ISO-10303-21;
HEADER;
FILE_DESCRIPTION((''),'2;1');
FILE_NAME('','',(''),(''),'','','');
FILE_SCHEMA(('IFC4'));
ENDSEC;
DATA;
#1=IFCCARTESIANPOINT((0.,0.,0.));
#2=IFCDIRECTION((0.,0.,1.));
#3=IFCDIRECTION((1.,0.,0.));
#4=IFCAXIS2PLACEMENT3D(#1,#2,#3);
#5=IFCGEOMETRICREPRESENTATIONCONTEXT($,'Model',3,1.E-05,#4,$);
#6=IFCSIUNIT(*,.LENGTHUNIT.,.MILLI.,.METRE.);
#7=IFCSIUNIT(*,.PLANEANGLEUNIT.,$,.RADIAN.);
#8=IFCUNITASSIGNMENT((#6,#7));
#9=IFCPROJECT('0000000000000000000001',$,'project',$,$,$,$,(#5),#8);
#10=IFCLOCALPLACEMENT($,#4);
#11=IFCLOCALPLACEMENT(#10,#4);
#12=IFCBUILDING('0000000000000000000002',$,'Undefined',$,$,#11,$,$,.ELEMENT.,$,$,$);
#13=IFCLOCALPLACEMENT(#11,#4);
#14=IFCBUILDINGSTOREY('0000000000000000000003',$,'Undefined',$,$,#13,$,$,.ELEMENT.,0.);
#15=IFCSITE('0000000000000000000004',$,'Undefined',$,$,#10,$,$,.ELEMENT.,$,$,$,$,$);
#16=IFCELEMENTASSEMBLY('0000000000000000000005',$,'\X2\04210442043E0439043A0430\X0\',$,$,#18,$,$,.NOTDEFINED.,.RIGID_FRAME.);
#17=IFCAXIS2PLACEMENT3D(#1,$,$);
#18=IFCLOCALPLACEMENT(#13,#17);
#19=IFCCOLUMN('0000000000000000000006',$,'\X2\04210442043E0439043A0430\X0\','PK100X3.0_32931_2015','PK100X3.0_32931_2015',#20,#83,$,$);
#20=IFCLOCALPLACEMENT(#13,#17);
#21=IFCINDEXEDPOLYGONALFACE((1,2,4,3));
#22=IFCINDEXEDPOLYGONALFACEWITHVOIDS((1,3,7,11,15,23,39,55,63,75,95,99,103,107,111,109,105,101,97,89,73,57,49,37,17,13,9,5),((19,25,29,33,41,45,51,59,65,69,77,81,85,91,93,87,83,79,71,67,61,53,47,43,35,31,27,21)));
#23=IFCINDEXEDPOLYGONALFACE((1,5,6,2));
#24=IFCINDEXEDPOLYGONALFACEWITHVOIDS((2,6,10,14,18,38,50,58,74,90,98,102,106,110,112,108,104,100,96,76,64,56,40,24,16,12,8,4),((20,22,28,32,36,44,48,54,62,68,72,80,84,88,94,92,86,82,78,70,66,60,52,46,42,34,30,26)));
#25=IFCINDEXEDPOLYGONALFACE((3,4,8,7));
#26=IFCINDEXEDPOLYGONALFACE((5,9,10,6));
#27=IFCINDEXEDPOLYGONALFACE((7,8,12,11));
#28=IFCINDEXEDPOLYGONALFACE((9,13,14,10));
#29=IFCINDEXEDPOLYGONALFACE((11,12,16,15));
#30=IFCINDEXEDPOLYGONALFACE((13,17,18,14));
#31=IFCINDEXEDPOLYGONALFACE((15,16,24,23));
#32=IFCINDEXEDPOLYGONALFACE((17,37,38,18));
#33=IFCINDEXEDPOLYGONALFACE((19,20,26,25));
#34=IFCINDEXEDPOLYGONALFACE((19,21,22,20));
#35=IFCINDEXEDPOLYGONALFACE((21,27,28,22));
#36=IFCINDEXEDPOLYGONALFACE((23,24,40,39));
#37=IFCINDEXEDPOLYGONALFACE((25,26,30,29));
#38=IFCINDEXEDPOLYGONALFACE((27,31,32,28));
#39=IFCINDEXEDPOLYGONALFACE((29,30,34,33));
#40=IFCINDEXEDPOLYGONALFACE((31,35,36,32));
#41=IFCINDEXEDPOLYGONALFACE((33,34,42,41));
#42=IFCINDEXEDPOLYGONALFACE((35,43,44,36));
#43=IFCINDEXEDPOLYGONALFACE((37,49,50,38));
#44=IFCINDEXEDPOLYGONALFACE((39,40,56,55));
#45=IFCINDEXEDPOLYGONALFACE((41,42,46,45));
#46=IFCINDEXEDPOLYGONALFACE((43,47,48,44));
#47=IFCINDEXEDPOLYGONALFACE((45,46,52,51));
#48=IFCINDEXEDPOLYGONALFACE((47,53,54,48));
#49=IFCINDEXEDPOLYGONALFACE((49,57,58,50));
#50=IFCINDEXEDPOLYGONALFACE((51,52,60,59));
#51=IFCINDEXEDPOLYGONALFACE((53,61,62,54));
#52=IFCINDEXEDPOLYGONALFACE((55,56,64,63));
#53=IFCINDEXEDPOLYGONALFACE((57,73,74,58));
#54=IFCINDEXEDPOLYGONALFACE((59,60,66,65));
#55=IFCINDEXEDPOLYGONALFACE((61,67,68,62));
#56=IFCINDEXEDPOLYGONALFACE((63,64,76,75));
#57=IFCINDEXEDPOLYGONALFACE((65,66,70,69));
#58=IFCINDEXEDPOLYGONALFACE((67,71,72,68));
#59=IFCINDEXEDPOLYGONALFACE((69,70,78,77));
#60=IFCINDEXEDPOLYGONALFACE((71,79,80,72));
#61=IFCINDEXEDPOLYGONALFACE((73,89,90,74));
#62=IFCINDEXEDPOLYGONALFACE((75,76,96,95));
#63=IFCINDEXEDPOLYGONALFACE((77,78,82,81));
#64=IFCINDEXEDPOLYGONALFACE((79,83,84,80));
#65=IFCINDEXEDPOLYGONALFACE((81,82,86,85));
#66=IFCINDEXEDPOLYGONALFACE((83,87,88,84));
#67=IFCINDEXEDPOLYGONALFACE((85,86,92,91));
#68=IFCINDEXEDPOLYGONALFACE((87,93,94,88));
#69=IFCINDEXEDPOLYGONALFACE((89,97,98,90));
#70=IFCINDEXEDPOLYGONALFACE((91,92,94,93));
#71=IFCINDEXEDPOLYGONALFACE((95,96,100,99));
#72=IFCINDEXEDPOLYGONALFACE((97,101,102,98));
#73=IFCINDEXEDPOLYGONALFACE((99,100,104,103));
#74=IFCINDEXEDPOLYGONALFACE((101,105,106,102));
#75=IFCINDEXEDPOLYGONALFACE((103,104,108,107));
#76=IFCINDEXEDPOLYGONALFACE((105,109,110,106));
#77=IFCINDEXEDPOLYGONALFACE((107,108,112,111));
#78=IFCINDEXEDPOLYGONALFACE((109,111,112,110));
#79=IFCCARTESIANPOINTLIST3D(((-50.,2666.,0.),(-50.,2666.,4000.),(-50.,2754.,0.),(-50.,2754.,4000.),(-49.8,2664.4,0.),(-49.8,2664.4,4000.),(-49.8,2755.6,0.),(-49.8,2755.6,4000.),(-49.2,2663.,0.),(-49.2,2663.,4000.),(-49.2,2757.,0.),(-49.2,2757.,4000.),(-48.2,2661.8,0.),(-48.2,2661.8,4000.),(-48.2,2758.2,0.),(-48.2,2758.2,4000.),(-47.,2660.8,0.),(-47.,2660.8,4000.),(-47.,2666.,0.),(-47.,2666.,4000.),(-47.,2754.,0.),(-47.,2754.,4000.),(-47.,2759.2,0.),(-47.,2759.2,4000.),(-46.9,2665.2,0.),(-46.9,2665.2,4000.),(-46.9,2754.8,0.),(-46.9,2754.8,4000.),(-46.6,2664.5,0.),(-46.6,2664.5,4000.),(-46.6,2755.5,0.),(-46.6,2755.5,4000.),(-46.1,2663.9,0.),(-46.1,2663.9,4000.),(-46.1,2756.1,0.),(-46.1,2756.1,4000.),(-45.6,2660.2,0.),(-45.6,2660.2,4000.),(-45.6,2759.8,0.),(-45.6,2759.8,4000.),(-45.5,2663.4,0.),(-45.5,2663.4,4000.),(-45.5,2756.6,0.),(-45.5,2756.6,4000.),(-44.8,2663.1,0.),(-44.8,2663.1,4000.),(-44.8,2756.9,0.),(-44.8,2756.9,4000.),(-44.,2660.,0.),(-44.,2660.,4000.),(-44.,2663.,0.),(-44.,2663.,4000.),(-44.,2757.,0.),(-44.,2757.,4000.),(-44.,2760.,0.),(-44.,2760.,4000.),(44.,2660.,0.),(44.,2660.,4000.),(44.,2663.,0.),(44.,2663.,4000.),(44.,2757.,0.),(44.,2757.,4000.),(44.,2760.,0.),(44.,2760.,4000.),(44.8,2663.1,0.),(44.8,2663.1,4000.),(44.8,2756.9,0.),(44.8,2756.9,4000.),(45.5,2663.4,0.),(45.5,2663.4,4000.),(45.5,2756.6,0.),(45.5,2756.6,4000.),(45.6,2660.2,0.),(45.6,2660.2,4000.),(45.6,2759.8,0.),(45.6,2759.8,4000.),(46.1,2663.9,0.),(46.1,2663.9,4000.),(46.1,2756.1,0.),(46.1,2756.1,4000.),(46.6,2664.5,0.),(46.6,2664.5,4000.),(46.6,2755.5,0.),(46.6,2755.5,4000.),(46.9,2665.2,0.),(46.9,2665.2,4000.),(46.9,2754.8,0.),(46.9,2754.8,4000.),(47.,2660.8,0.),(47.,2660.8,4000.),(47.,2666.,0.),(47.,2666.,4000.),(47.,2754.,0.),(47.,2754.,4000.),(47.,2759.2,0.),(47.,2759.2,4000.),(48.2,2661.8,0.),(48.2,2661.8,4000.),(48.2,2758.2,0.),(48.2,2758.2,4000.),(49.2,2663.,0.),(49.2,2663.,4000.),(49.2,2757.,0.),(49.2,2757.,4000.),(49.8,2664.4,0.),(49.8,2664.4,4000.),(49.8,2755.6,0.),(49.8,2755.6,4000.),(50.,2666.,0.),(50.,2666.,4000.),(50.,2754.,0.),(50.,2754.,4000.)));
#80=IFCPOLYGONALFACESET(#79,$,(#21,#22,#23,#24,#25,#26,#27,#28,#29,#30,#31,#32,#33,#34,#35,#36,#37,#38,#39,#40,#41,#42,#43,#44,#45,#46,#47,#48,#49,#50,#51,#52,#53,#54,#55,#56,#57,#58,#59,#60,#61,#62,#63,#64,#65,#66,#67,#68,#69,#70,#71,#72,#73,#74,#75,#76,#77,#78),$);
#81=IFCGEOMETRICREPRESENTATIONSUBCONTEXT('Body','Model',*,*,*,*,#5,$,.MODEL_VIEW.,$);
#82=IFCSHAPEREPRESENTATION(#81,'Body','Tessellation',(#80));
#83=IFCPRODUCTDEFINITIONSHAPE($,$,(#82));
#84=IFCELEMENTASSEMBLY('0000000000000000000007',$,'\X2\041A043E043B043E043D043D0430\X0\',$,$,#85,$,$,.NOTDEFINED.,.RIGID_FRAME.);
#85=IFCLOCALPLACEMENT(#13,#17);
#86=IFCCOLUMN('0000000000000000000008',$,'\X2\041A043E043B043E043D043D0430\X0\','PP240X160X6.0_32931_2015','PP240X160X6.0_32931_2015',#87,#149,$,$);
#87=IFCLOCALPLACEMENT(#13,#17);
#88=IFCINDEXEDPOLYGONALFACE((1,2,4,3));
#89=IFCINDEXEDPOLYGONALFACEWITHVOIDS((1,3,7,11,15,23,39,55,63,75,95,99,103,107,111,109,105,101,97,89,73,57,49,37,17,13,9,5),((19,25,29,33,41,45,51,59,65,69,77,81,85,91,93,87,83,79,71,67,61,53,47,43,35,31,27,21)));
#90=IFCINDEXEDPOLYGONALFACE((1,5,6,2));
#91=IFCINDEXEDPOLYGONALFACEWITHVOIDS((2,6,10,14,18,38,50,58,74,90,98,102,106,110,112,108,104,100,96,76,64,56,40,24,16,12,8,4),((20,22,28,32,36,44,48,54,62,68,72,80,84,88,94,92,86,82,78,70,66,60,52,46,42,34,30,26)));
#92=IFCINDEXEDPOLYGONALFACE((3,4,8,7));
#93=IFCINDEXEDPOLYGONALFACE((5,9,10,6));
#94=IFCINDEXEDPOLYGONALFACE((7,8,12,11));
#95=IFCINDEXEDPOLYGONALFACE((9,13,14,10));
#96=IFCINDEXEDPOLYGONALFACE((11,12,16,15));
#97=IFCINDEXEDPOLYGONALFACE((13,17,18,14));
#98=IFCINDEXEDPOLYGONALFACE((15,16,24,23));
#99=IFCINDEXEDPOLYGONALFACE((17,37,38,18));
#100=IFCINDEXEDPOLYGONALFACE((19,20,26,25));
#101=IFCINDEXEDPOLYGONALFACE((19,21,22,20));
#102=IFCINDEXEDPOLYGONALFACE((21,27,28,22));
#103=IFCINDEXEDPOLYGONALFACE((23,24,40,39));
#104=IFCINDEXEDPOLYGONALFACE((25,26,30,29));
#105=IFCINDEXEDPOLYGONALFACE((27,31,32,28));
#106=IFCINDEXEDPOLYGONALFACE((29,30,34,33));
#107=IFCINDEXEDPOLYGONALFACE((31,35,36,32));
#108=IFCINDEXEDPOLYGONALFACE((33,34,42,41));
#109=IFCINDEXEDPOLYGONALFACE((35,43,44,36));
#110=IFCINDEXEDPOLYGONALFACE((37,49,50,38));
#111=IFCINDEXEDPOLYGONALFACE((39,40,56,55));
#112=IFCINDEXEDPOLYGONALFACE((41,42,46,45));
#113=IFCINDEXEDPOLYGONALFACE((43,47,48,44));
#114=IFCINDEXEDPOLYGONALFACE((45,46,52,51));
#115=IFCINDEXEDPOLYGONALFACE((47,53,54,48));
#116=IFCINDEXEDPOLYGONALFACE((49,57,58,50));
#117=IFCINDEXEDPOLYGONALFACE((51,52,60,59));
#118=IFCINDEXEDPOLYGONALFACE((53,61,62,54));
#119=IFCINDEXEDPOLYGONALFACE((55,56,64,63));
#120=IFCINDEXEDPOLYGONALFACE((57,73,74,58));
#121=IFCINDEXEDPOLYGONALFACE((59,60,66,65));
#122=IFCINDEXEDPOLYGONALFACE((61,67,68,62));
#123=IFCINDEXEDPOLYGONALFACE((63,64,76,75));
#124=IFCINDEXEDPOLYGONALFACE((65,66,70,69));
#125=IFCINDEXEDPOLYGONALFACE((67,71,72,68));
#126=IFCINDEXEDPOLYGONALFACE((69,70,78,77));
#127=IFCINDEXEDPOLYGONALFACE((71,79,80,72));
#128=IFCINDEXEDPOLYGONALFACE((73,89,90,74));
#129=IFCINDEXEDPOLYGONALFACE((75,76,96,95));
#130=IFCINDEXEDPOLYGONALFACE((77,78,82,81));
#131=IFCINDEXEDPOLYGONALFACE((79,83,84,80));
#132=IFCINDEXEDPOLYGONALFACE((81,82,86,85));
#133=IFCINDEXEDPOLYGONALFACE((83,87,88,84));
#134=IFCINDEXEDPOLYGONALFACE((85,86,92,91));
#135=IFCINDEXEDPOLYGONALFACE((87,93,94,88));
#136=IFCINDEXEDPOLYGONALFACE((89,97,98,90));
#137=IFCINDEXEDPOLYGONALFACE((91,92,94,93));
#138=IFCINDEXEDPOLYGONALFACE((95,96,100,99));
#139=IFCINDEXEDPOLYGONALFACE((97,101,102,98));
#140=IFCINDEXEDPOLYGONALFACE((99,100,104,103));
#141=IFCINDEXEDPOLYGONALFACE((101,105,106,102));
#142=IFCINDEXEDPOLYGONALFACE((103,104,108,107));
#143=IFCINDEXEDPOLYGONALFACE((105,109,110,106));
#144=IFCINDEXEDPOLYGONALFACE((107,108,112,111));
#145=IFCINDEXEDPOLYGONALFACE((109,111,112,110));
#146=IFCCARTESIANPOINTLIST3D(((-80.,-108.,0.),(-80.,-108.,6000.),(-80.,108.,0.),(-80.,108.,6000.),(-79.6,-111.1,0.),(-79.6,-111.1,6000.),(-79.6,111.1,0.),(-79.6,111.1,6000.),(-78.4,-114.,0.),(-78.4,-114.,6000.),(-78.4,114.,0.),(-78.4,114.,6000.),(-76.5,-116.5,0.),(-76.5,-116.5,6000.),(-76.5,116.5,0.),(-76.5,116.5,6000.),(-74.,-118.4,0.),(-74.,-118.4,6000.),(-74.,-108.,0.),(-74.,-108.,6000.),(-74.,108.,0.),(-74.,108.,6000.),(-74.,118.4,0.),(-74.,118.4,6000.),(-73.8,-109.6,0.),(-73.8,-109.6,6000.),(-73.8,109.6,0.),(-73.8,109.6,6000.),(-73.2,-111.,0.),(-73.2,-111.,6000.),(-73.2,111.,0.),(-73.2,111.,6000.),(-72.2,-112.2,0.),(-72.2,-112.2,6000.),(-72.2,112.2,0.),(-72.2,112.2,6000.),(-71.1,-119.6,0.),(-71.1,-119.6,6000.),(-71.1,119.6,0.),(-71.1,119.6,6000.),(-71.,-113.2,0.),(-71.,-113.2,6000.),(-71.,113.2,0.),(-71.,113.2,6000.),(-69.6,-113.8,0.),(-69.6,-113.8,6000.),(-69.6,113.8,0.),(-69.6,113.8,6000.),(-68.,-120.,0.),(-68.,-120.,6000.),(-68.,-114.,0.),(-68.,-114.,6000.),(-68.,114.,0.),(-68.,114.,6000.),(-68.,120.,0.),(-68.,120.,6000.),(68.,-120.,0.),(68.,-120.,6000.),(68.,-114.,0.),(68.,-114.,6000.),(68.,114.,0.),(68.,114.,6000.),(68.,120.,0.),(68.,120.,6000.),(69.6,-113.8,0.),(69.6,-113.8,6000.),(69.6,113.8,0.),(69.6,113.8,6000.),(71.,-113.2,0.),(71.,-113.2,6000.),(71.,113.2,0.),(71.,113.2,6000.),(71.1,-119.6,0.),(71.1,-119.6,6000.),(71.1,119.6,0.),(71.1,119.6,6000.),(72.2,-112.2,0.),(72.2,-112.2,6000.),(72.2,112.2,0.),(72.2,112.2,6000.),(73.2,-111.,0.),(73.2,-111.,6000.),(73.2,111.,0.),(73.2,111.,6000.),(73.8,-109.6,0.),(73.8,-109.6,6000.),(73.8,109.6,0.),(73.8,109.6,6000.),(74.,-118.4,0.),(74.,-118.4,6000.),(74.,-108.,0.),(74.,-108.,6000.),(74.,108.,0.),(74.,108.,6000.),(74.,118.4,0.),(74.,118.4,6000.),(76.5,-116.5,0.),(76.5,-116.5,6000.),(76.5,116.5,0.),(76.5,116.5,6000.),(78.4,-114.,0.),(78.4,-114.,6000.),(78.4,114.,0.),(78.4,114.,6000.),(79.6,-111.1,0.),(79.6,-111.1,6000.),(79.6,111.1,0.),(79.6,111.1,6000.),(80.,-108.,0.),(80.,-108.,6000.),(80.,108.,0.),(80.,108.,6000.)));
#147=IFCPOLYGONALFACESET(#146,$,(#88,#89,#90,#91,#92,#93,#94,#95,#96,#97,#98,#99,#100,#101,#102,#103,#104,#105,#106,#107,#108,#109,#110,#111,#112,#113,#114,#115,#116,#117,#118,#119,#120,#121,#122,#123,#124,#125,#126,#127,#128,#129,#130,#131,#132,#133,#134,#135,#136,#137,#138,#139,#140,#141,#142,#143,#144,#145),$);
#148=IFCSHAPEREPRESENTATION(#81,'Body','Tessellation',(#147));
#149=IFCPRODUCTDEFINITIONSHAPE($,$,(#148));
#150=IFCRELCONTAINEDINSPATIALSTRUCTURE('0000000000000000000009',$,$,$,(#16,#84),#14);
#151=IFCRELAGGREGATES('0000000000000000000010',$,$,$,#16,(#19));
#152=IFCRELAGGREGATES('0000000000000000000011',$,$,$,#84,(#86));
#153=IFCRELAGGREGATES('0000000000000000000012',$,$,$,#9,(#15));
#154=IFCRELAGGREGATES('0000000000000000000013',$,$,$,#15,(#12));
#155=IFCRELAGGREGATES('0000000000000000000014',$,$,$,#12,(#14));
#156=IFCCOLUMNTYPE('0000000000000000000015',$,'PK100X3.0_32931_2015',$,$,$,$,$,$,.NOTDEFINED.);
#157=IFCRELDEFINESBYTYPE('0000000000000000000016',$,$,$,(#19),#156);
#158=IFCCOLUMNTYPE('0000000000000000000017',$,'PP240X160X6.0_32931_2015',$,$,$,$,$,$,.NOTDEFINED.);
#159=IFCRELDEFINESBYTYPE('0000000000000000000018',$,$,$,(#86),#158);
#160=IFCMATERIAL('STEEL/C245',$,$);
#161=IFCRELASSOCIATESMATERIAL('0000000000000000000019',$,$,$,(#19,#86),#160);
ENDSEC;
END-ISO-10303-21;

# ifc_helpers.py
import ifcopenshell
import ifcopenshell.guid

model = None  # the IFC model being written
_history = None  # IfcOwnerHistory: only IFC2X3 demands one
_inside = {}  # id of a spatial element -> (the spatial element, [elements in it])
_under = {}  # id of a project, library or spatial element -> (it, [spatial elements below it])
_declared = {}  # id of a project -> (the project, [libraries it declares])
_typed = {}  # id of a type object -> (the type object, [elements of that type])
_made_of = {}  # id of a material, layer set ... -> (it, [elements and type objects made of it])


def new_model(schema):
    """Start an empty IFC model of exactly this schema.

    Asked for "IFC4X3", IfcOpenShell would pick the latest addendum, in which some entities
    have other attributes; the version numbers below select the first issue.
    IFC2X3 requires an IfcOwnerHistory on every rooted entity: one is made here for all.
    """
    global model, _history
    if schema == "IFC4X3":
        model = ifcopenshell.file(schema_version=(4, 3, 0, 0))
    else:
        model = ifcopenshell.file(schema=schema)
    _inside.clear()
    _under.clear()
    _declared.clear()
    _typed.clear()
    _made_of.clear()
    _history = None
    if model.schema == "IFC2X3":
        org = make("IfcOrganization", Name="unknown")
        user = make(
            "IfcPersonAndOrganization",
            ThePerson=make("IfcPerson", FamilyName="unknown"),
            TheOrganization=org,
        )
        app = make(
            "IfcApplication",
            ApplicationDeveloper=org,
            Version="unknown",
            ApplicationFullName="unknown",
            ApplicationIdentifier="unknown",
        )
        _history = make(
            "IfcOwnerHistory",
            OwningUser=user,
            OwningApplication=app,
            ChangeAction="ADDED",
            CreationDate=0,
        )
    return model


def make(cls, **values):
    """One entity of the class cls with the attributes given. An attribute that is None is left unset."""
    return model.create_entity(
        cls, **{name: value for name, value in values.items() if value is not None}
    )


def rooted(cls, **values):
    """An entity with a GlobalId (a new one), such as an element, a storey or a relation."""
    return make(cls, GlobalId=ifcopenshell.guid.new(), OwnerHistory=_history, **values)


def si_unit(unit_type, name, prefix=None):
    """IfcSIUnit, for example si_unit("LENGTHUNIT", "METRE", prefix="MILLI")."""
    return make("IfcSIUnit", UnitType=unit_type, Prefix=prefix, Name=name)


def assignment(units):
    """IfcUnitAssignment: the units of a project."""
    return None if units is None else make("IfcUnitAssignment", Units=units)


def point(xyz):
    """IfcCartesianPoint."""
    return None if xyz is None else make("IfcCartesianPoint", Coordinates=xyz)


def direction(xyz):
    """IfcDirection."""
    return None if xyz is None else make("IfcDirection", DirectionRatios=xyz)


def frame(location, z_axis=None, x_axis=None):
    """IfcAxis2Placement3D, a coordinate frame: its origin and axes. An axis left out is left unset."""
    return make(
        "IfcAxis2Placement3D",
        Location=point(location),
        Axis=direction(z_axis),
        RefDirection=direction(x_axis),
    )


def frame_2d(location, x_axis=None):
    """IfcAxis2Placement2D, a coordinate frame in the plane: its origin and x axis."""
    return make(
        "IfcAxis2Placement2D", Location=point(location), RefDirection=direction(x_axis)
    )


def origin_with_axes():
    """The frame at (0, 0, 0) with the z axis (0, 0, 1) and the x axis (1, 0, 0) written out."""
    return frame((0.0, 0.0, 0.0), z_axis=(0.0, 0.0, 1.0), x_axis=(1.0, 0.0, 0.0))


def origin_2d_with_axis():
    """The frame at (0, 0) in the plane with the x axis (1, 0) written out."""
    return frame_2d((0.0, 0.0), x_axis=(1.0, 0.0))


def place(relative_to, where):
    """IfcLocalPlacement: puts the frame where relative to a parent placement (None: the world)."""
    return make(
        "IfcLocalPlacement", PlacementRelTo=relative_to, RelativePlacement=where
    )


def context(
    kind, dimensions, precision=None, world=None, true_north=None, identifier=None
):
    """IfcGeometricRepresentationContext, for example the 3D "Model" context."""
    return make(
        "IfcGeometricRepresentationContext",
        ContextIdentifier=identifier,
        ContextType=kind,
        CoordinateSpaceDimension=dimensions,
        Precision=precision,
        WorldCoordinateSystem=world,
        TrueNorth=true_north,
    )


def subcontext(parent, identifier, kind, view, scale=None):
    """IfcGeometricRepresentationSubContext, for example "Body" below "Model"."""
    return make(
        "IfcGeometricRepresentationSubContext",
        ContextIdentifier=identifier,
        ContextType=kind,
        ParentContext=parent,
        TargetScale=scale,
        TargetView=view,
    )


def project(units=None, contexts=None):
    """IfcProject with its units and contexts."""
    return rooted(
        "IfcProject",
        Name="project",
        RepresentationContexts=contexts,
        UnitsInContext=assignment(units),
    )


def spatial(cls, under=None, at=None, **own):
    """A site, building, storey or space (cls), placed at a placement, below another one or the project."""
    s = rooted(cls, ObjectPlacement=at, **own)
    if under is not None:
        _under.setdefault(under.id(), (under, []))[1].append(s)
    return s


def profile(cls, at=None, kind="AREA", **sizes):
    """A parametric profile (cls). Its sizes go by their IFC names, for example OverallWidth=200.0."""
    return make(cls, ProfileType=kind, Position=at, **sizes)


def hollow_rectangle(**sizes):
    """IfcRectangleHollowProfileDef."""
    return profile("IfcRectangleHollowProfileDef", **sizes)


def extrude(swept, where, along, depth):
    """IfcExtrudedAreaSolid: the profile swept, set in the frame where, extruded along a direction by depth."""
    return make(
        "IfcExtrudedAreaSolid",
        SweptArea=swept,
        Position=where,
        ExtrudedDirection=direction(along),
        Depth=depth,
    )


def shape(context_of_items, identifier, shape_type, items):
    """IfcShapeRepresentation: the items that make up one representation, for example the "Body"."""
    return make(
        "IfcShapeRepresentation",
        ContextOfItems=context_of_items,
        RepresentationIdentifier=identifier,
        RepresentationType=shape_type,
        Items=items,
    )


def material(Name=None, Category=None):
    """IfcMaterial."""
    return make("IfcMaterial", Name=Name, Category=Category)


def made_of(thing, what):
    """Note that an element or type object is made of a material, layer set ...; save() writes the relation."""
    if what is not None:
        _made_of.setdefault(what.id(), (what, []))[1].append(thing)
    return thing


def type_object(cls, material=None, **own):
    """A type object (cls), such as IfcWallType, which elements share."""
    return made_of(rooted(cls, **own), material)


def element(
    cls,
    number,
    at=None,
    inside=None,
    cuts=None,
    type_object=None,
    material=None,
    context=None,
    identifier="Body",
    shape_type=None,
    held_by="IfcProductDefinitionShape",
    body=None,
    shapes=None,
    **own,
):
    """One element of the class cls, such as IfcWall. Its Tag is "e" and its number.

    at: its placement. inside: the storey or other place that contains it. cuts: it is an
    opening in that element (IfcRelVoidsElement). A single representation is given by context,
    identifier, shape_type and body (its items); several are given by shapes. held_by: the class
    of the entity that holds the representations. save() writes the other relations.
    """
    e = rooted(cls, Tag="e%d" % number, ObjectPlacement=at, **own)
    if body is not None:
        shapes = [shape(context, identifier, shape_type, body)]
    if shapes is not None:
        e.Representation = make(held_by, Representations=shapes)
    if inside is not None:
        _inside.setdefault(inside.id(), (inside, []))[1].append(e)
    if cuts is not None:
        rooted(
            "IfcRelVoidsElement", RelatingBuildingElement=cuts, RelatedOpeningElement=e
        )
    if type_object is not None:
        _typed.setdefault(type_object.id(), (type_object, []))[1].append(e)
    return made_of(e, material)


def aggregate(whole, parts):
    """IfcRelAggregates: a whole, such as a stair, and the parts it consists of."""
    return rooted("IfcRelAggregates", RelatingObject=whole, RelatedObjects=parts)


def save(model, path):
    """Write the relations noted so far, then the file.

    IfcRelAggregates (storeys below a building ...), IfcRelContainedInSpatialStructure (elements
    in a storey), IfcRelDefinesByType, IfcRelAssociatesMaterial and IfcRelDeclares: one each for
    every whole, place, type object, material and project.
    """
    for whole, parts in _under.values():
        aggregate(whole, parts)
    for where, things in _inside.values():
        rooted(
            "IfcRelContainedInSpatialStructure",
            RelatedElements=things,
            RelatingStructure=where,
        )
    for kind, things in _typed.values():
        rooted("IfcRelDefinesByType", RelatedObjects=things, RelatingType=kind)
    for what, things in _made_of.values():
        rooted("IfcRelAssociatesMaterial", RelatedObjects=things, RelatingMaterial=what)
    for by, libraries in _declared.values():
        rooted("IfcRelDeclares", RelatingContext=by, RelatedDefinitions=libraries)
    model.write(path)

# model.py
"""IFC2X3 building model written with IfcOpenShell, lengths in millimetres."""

from ifc_helpers import new_model, si_unit, frame, origin_with_axes, origin_2d_with_axis, place, context, subcontext, project, spatial, hollow_rectangle, extrude, material, type_object, element, aggregate, save


model = new_model("IFC2X3")

# Units and contexts
model_context = context("Model", 3, precision=1e-05, world=origin_with_axes())
body_context = subcontext(model_context, "Body", "Model", "MODEL_VIEW")
ifc_project = project(units=[si_unit("LENGTHUNIT", "METRE", prefix="MILLI"), si_unit("PLANEANGLEUNIT", "RADIAN")], contexts=[model_context])

# Site, building, storey
site_placement = place(None, origin_with_axes())
site = spatial("IfcSite", under=ifc_project, at=site_placement, Name="Undefined", CompositionType="ELEMENT")
building_placement = place(site_placement, origin_with_axes())
building = spatial("IfcBuilding", under=site, at=building_placement, Name="Undefined", CompositionType="ELEMENT")
storey_placement = place(building_placement, origin_with_axes())
storey = spatial("IfcBuildingStorey", under=building, at=storey_placement, Name="Undefined", CompositionType="ELEMENT", Elevation=0.0)

# Element assemblies, columns
assembly_1_placement = place(storey_placement, origin_with_axes())
assembly_1 = element("IfcElementAssembly", 1, at=assembly_1_placement, inside=storey, Name="Стойка", AssemblyPlace="NOTDEFINED", PredefinedType="RIGID_FRAME")
ifc_material = material(Name="STEEL/C245")
column_type_1 = type_object("IfcColumnType", Name="PK100X3.0_32931_2015", PredefinedType="NOTDEFINED")
column_1_placement = place(assembly_1_placement, frame((0.0, 2710.0, 0.0), z_axis=(0.0, 0.0, 1.0), x_axis=(0.0, 1.0, 0.0)))
column_1 = element("IfcColumn", 2, at=column_1_placement, type_object=column_type_1, material=ifc_material, Name="Стойка", Description="PK100X3.0_32931_2015", ObjectType="PK100X3.0_32931_2015", context=body_context, shape_type="SweptSolid", body=[
    extrude(hollow_rectangle(XDim=100.0, YDim=100.0, WallThickness=3.0, InnerFilletRadius=3.0, OuterFilletRadius=6.0, at=origin_2d_with_axis()), frame((0.0, 0.0, 4000.0), z_axis=(0.0, 0.0, -1.0), x_axis=(0.0, 1.0, 0.0)), (0.0, 0.0, 1.0), 4000.0),
])
aggregate(assembly_1, [column_1])
assembly_2_placement = place(storey_placement, origin_with_axes())
assembly_2 = element("IfcElementAssembly", 3, at=assembly_2_placement, inside=storey, Name="Колонна", AssemblyPlace="NOTDEFINED", PredefinedType="RIGID_FRAME")
column_type_2 = type_object("IfcColumnType", Name="PP240X160X6.0_32931_2015", PredefinedType="NOTDEFINED")
column_2_placement = place(assembly_2_placement, frame((0.0, 0.0, 0.0), z_axis=(0.0, 0.0, 1.0), x_axis=(0.0, 1.0, 0.0)))
column_2 = element("IfcColumn", 4, at=column_2_placement, type_object=column_type_2, material=ifc_material, Name="Колонна", Description="PP240X160X6.0_32931_2015", ObjectType="PP240X160X6.0_32931_2015", context=body_context, shape_type="SweptSolid", body=[
    extrude(hollow_rectangle(XDim=160.0, YDim=240.0, WallThickness=6.0, InnerFilletRadius=6.0, OuterFilletRadius=12.0, at=origin_2d_with_axis()), frame((0.0, 0.0, 6000.0), z_axis=(0.0, 0.0, -1.0), x_axis=(0.0, 1.0, 0.0)), (0.0, 0.0, 1.0), 6000.0),
])
aggregate(assembly_2, [column_2])

save(model, "model.ifc")
